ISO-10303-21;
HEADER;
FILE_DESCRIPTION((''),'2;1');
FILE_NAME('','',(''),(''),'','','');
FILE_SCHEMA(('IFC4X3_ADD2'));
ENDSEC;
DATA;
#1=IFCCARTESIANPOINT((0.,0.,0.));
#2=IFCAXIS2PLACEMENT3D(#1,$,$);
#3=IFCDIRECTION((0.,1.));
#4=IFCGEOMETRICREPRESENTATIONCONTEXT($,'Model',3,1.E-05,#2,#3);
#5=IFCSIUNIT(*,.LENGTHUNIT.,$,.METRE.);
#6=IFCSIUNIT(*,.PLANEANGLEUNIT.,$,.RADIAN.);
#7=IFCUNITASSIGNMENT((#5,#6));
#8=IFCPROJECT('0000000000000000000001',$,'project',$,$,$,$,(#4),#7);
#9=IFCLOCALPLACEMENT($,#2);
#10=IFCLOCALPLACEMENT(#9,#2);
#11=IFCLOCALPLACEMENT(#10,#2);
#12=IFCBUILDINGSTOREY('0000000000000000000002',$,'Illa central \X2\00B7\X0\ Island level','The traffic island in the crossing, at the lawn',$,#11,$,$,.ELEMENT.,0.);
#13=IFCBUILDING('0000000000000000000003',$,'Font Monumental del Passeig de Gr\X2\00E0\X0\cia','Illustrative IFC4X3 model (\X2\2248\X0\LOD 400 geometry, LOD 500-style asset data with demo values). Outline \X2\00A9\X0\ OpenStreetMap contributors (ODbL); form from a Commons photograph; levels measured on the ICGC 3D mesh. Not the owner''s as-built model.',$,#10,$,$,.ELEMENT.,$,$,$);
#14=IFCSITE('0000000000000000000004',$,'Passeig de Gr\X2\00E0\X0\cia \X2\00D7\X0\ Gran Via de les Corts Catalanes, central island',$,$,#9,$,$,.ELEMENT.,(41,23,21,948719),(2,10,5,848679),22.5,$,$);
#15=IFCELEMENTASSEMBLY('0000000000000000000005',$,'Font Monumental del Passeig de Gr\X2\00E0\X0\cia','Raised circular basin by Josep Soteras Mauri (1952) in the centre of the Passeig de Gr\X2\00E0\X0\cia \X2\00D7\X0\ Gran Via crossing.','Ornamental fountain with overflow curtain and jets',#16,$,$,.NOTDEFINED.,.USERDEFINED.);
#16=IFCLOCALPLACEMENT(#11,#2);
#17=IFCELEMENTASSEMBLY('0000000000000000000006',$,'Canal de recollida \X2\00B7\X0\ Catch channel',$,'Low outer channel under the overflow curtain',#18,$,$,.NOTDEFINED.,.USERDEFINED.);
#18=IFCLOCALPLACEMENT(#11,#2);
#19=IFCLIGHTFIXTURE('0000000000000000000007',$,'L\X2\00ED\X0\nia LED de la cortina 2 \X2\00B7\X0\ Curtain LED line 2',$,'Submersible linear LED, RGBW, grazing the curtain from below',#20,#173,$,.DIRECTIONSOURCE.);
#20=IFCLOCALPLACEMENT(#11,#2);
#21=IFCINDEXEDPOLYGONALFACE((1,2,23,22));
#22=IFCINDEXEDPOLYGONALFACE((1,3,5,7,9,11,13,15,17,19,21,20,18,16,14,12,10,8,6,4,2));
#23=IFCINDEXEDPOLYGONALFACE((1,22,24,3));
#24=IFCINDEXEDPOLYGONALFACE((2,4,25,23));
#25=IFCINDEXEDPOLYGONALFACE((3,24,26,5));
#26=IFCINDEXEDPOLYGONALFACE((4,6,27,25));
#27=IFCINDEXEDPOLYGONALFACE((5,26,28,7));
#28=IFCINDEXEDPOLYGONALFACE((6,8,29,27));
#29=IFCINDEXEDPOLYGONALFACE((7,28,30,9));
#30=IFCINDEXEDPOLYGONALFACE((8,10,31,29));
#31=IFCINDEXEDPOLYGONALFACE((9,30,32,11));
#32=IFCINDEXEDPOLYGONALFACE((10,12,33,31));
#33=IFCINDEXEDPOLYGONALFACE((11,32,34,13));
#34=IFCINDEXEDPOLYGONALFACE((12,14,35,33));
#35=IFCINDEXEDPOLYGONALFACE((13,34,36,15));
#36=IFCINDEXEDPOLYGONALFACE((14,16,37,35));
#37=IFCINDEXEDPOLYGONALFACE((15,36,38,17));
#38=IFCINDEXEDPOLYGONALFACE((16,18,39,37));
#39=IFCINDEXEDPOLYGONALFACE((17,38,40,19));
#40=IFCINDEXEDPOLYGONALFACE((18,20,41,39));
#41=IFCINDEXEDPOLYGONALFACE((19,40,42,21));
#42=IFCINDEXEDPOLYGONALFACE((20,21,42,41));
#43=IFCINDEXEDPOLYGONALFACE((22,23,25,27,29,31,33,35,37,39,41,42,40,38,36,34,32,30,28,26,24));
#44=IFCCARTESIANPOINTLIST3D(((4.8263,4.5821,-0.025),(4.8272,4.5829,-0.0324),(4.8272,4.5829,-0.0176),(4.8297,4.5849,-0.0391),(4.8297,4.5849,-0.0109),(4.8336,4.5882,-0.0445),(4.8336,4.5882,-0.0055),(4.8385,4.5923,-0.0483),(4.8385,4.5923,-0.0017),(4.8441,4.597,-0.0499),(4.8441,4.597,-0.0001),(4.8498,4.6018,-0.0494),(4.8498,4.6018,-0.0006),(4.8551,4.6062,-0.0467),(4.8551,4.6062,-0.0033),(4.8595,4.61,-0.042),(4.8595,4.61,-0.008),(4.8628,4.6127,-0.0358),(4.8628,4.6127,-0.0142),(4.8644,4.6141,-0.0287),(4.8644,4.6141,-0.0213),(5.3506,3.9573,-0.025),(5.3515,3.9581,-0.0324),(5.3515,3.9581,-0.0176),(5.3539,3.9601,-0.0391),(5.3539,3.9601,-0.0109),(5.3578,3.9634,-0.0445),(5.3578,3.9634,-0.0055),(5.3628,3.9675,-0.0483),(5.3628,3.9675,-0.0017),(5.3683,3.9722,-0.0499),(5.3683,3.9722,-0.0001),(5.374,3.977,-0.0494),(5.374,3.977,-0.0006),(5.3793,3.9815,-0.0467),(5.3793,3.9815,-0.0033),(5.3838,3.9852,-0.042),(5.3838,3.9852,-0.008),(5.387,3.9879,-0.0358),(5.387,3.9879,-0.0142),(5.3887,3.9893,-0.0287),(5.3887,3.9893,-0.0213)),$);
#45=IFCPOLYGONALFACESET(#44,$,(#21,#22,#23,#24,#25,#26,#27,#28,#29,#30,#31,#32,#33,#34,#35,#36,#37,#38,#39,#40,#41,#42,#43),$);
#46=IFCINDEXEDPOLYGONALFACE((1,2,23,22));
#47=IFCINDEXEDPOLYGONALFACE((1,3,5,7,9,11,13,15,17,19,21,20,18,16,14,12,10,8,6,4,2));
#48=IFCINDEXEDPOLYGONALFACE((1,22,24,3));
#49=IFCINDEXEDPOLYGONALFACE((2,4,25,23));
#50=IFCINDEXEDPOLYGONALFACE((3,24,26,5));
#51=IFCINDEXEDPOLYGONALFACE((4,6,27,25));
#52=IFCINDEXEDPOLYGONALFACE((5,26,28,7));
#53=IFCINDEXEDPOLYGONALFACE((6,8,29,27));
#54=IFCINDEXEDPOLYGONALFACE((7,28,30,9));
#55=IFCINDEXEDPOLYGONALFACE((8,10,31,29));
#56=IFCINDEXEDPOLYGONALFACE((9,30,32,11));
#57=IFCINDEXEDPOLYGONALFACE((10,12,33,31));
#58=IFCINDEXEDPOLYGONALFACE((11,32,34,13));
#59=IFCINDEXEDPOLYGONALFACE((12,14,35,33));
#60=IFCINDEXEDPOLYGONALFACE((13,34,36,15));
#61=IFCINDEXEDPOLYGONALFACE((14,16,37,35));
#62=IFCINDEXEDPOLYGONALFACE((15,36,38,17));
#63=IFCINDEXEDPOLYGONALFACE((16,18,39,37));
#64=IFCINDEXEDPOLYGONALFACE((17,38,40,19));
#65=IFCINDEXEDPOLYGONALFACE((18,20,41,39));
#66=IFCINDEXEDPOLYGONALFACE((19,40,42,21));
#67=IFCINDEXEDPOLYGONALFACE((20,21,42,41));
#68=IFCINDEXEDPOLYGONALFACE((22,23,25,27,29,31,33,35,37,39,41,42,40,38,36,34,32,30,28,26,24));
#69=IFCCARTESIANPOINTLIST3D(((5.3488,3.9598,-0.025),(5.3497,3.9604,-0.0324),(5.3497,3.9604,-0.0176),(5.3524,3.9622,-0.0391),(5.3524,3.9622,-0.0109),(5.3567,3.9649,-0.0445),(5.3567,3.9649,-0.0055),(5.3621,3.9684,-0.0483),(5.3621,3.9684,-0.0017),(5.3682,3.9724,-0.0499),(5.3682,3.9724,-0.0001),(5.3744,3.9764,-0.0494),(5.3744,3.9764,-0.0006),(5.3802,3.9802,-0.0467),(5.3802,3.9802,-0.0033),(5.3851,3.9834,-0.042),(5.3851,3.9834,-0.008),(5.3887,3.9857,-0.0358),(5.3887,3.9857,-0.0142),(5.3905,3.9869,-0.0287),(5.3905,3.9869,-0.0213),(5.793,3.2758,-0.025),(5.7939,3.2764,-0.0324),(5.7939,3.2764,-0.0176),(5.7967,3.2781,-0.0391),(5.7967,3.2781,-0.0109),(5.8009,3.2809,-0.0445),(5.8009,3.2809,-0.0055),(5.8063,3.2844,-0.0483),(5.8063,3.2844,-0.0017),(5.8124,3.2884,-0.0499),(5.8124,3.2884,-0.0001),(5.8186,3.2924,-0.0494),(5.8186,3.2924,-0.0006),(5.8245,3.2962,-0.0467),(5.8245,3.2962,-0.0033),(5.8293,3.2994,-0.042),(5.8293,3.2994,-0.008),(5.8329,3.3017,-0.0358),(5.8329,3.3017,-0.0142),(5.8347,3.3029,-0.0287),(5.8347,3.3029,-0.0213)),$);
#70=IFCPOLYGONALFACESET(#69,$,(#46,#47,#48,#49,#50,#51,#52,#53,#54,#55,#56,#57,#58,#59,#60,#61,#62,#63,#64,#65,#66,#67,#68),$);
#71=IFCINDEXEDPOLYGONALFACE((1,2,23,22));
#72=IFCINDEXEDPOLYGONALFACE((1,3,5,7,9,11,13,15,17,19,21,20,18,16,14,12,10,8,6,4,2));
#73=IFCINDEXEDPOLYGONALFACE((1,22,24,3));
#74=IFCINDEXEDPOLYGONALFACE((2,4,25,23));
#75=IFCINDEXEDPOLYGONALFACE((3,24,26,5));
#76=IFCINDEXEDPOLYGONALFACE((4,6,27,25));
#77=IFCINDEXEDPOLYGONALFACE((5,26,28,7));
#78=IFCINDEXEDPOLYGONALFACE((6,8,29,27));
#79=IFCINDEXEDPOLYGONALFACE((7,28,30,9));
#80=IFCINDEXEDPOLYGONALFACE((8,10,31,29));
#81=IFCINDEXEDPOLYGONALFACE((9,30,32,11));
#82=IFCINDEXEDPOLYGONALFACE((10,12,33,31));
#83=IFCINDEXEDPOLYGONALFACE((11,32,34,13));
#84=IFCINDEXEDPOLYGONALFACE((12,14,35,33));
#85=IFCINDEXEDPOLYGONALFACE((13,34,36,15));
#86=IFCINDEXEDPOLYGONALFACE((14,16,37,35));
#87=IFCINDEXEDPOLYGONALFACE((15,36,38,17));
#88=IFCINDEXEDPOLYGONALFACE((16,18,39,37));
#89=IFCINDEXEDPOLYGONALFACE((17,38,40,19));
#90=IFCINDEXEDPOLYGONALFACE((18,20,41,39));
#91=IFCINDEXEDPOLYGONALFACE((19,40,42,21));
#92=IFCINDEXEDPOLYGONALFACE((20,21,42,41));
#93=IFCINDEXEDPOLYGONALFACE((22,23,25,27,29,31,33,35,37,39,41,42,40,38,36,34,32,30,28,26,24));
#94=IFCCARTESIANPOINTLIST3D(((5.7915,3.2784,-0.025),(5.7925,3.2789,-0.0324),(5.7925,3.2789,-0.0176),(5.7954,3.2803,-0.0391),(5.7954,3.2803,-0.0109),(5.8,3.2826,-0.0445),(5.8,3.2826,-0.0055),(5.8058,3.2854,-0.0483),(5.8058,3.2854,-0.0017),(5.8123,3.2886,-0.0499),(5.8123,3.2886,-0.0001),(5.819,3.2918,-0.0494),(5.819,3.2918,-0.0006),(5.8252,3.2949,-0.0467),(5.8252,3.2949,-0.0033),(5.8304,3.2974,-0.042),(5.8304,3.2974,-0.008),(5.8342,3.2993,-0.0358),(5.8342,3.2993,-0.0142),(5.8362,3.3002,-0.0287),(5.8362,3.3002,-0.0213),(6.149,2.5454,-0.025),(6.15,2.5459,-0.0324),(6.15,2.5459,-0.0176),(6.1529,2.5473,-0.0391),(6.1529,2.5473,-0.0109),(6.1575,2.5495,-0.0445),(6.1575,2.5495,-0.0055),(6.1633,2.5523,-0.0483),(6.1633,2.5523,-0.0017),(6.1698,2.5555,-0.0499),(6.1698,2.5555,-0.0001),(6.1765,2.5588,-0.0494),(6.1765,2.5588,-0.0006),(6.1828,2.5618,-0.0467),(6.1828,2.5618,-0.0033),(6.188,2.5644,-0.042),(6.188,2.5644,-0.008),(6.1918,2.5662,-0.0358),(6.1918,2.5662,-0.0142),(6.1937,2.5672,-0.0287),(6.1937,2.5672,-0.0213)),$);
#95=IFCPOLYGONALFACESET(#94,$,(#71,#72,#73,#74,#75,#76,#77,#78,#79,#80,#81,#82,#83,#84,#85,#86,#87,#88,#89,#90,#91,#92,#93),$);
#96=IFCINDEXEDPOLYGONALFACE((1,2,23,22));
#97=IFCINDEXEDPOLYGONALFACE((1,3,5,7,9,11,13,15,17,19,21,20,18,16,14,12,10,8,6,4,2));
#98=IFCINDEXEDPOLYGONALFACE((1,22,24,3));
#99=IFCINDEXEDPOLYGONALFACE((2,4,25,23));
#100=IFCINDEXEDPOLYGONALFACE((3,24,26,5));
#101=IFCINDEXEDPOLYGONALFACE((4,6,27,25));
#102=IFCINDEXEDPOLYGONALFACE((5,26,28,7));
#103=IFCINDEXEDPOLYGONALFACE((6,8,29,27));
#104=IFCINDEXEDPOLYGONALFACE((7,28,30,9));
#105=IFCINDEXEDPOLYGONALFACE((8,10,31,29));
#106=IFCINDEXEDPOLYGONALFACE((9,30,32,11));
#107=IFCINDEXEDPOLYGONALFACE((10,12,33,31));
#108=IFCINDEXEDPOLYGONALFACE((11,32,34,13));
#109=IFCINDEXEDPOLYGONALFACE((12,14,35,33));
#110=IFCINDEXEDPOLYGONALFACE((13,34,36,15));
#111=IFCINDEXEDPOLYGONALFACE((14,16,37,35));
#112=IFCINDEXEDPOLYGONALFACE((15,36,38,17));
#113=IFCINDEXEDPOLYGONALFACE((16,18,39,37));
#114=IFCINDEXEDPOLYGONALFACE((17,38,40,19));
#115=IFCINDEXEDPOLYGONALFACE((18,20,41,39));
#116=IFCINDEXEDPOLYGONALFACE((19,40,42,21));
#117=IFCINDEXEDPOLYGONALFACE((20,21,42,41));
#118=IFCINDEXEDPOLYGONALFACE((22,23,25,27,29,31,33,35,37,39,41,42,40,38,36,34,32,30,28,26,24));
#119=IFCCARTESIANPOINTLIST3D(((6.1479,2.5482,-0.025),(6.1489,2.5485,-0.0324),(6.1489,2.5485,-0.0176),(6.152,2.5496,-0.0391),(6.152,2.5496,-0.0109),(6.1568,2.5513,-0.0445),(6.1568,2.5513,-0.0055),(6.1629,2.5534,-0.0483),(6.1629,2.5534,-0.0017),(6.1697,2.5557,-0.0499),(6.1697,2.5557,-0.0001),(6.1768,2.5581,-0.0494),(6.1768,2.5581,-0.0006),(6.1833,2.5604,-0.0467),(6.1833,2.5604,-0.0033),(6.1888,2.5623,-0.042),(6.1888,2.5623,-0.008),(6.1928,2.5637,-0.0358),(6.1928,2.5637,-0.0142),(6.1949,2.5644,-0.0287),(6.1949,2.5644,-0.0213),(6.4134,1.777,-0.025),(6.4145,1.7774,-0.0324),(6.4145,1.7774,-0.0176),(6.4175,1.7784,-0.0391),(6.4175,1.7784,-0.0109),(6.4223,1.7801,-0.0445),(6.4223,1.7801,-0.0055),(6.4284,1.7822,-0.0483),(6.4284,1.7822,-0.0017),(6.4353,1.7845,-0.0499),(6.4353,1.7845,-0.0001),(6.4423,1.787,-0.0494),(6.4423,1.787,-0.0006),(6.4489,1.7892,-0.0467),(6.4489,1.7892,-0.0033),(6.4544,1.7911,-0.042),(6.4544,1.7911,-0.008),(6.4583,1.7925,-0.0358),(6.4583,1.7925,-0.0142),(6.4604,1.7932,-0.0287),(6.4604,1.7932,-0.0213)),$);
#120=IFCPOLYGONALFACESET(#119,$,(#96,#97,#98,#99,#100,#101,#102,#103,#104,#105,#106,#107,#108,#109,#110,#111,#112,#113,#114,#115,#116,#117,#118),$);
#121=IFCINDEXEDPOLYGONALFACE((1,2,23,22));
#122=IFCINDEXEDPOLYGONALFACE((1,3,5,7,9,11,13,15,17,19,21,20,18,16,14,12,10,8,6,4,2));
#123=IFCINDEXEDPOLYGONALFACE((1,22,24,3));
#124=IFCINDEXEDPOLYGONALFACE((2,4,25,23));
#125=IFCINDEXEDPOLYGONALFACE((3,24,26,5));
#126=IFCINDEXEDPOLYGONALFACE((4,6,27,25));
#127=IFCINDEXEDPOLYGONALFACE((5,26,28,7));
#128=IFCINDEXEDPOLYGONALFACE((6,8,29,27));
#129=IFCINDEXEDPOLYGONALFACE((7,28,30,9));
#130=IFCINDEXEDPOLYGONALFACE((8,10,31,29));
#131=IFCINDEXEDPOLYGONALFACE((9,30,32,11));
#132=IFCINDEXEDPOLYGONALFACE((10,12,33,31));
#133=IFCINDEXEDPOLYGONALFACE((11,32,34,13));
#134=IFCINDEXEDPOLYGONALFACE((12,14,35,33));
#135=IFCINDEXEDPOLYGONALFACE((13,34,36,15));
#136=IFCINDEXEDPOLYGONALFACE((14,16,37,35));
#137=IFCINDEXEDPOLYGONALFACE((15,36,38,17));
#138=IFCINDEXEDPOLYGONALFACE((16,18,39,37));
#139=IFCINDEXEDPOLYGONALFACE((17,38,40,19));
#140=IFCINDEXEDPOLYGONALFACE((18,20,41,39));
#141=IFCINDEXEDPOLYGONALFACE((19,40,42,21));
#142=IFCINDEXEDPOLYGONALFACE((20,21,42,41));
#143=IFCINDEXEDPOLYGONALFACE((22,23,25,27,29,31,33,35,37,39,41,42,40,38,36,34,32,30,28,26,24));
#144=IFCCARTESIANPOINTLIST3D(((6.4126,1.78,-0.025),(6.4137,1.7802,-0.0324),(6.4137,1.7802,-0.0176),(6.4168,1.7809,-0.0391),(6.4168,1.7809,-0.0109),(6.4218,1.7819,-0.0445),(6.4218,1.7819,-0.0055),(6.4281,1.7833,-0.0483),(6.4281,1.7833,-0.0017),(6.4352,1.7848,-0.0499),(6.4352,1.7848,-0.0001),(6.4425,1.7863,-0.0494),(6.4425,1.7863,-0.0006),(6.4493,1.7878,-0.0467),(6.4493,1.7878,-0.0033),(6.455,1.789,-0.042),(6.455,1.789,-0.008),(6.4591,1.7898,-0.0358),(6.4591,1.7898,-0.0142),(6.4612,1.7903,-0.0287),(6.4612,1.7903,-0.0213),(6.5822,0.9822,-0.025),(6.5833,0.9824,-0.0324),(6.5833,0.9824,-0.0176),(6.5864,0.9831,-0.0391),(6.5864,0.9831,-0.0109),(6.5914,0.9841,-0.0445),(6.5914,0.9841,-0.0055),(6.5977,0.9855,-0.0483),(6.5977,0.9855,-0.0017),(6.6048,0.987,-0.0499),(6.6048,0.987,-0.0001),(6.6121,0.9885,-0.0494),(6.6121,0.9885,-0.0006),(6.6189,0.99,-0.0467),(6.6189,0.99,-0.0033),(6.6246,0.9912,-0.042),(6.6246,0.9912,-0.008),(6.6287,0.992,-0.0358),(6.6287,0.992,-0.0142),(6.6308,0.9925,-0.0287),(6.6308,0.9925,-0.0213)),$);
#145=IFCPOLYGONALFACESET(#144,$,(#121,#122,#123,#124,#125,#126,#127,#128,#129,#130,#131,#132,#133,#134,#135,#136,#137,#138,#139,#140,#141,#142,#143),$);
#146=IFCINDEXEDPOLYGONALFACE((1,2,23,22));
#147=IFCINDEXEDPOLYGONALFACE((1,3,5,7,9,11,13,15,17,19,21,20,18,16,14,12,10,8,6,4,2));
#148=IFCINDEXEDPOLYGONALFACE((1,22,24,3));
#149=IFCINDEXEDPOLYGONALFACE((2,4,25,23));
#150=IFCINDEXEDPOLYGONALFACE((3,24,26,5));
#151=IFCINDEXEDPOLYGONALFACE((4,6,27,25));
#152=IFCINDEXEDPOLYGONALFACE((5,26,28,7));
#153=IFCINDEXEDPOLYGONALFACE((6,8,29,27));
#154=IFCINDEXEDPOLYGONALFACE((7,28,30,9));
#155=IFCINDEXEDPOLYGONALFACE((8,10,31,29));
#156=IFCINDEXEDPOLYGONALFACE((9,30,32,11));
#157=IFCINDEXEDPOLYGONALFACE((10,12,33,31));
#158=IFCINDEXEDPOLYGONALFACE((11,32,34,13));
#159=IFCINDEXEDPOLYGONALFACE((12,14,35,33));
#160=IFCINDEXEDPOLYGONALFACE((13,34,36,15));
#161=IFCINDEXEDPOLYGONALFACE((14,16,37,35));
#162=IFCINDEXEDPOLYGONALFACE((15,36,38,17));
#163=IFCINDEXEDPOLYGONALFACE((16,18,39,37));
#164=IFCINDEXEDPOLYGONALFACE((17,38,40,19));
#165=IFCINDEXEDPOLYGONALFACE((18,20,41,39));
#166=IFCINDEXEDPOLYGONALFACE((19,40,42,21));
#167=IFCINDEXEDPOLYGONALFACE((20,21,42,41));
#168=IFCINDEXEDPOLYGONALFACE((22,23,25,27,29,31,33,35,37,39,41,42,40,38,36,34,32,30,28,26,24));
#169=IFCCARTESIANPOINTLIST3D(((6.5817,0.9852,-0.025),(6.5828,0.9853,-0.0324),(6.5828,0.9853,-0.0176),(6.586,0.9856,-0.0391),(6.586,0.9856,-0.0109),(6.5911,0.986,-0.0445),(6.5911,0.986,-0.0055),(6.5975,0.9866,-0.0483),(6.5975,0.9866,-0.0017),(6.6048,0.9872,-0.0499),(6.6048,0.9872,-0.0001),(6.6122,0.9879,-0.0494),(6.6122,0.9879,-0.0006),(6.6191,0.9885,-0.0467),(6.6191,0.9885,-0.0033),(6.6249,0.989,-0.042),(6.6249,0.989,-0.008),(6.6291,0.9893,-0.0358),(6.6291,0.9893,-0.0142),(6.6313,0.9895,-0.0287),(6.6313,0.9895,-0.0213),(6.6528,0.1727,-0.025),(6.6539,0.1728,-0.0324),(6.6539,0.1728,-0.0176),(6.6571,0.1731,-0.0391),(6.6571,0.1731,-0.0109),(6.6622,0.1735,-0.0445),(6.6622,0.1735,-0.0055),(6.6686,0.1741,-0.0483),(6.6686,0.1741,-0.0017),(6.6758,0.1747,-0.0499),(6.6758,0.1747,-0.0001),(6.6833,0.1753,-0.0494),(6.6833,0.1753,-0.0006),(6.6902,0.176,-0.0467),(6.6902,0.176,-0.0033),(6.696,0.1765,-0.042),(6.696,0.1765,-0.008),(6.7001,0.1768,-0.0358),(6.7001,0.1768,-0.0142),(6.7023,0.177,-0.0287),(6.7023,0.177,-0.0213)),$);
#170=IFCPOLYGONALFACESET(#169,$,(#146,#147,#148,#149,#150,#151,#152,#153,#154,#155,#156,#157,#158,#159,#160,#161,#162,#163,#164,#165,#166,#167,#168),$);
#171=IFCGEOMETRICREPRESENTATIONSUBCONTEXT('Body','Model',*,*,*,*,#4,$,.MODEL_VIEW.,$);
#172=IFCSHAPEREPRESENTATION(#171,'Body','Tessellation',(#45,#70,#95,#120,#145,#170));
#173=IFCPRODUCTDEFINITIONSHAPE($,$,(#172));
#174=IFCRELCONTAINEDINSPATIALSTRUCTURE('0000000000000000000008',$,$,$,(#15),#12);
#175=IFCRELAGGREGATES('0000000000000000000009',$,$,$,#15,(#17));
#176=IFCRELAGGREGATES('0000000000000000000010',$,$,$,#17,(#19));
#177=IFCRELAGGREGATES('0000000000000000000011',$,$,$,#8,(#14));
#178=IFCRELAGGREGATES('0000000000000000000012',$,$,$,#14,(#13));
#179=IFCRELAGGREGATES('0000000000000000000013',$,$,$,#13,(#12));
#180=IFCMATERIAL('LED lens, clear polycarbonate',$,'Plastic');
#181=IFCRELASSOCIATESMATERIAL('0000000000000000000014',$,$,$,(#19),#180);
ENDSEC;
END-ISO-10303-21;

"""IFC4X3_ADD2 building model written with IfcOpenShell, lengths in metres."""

from ifc_helpers import new_model, si_unit, direction, frame, origin, origin_2d_with_axis, place, context, subcontext, project, spatial, circle, extrude, material, element, aggregate, save


model = new_model("IFC4X3_ADD2")

# Units and contexts
model_context = context("Model", 3, precision=1e-05, world=origin(), true_north=direction((0.0, 1.0)))
body_context = subcontext(model_context, "Body", "Model", "MODEL_VIEW")
ifc_project = project(units=[si_unit("LENGTHUNIT", "METRE"), si_unit("PLANEANGLEUNIT", "RADIAN")], contexts=[model_context])

# Site, building, storey
site_placement = place(None, origin())
site = spatial("IfcSite", under=ifc_project, at=site_placement, Name="Passeig de Gràcia × Gran Via de les Corts Catalanes, central island", CompositionType="ELEMENT", RefLatitude=(41, 23, 21, 948719), RefLongitude=(2, 10, 5, 848679), RefElevation=22.5)
building_placement = place(site_placement, origin())
building = spatial("IfcBuilding", under=site, at=building_placement, Name="Font Monumental del Passeig de Gràcia", Description="Illustrative IFC4X3 model (≈LOD 400 geometry, LOD 500-style asset data with demo values). Outline © OpenStreetMap contributors (ODbL); form from a Commons photograph; levels measured on the ICGC 3D mesh. Not the owner's as-built model.", CompositionType="ELEMENT")
storey_placement = place(building_placement, origin())
storey = spatial("IfcBuildingStorey", under=building, at=storey_placement, Name="Illa central · Island level", Description="The traffic island in the crossing, at the lawn", CompositionType="ELEMENT", Elevation=0.0)

# Element assemblies, light fixture
assembly_1_placement = place(building_placement, origin())
assembly_1 = element("IfcElementAssembly", 1, at=assembly_1_placement, inside=storey, Name="Font Monumental del Passeig de Gràcia", Description="Raised circular basin by Josep Soteras Mauri (1952) in the centre of the Passeig de Gràcia × Gran Via crossing.", ObjectType="Ornamental fountain with overflow curtain and jets", AssemblyPlace="NOTDEFINED", PredefinedType="USERDEFINED")
assembly_2_placement = place(building_placement, origin())
assembly_2 = element("IfcElementAssembly", 2, at=assembly_2_placement, Name="Canal de recollida · Catch channel", ObjectType="Low outer channel under the overflow curtain", AssemblyPlace="NOTDEFINED", PredefinedType="USERDEFINED")
ifc_material_1 = material(Name="LED lens, clear polycarbonate", Category="Plastic")
light_fixture_1_placement = place(building_placement, origin())
light_fixture_1 = element("IfcLightFixture", 3, at=light_fixture_1_placement, material=ifc_material_1, Name="Línia LED de la cortina 2 · Curtain LED line 2", ObjectType="Submersible linear LED, RGBW, grazing the curtain from below", PredefinedType="DIRECTIONSOURCE", context=body_context, shape_type="SweptSolid", body=[
    extrude(circle(Radius=0.025, at=origin_2d_with_axis()), frame((4.8455, 4.5982, -0.025), z_axis=(0.642788, -0.766044, 0.0), x_axis=(-0.766044, -0.642788, 0.0)), (0.0, 0.0, 1.0), 0.8156),
    extrude(circle(Radius=0.025, at=origin_2d_with_axis()), frame((5.3698, 3.9734, -0.025), z_axis=(0.544639, -0.838671, 0.0), x_axis=(-0.838671, -0.544639, 0.0)), (0.0, 0.0, 1.0), 0.8156),
    extrude(circle(Radius=0.025, at=origin_2d_with_axis()), frame((5.814, 3.2894, -0.025), z_axis=(0.438371, -0.898794, 0.0), x_axis=(-0.898794, -0.438371, 0.0)), (0.0, 0.0, 1.0), 0.8156),
    extrude(circle(Radius=0.025, at=origin_2d_with_axis()), frame((6.1715, 2.5563, -0.025), z_axis=(0.325568, -0.945519, 0.0), x_axis=(-0.945519, -0.325568, 0.0)), (0.0, 0.0, 1.0), 0.8156),
    extrude(circle(Radius=0.025, at=origin_2d_with_axis()), frame((6.4371, 1.7852, -0.025), z_axis=(0.207912, -0.978148, 0.0), x_axis=(-0.978148, -0.207912, 0.0)), (0.0, 0.0, 1.0), 0.8156),
    extrude(circle(Radius=0.025, at=origin_2d_with_axis()), frame((6.6066, 0.9874, -0.025), z_axis=(0.087156, -0.996195, 0.0), x_axis=(-0.996195, -0.087156, 0.0)), (0.0, 0.0, 1.0), 0.8156),
])
aggregate(assembly_1, [assembly_2])
aggregate(assembly_2, [light_fixture_1])

save(model, "model.ifc")
